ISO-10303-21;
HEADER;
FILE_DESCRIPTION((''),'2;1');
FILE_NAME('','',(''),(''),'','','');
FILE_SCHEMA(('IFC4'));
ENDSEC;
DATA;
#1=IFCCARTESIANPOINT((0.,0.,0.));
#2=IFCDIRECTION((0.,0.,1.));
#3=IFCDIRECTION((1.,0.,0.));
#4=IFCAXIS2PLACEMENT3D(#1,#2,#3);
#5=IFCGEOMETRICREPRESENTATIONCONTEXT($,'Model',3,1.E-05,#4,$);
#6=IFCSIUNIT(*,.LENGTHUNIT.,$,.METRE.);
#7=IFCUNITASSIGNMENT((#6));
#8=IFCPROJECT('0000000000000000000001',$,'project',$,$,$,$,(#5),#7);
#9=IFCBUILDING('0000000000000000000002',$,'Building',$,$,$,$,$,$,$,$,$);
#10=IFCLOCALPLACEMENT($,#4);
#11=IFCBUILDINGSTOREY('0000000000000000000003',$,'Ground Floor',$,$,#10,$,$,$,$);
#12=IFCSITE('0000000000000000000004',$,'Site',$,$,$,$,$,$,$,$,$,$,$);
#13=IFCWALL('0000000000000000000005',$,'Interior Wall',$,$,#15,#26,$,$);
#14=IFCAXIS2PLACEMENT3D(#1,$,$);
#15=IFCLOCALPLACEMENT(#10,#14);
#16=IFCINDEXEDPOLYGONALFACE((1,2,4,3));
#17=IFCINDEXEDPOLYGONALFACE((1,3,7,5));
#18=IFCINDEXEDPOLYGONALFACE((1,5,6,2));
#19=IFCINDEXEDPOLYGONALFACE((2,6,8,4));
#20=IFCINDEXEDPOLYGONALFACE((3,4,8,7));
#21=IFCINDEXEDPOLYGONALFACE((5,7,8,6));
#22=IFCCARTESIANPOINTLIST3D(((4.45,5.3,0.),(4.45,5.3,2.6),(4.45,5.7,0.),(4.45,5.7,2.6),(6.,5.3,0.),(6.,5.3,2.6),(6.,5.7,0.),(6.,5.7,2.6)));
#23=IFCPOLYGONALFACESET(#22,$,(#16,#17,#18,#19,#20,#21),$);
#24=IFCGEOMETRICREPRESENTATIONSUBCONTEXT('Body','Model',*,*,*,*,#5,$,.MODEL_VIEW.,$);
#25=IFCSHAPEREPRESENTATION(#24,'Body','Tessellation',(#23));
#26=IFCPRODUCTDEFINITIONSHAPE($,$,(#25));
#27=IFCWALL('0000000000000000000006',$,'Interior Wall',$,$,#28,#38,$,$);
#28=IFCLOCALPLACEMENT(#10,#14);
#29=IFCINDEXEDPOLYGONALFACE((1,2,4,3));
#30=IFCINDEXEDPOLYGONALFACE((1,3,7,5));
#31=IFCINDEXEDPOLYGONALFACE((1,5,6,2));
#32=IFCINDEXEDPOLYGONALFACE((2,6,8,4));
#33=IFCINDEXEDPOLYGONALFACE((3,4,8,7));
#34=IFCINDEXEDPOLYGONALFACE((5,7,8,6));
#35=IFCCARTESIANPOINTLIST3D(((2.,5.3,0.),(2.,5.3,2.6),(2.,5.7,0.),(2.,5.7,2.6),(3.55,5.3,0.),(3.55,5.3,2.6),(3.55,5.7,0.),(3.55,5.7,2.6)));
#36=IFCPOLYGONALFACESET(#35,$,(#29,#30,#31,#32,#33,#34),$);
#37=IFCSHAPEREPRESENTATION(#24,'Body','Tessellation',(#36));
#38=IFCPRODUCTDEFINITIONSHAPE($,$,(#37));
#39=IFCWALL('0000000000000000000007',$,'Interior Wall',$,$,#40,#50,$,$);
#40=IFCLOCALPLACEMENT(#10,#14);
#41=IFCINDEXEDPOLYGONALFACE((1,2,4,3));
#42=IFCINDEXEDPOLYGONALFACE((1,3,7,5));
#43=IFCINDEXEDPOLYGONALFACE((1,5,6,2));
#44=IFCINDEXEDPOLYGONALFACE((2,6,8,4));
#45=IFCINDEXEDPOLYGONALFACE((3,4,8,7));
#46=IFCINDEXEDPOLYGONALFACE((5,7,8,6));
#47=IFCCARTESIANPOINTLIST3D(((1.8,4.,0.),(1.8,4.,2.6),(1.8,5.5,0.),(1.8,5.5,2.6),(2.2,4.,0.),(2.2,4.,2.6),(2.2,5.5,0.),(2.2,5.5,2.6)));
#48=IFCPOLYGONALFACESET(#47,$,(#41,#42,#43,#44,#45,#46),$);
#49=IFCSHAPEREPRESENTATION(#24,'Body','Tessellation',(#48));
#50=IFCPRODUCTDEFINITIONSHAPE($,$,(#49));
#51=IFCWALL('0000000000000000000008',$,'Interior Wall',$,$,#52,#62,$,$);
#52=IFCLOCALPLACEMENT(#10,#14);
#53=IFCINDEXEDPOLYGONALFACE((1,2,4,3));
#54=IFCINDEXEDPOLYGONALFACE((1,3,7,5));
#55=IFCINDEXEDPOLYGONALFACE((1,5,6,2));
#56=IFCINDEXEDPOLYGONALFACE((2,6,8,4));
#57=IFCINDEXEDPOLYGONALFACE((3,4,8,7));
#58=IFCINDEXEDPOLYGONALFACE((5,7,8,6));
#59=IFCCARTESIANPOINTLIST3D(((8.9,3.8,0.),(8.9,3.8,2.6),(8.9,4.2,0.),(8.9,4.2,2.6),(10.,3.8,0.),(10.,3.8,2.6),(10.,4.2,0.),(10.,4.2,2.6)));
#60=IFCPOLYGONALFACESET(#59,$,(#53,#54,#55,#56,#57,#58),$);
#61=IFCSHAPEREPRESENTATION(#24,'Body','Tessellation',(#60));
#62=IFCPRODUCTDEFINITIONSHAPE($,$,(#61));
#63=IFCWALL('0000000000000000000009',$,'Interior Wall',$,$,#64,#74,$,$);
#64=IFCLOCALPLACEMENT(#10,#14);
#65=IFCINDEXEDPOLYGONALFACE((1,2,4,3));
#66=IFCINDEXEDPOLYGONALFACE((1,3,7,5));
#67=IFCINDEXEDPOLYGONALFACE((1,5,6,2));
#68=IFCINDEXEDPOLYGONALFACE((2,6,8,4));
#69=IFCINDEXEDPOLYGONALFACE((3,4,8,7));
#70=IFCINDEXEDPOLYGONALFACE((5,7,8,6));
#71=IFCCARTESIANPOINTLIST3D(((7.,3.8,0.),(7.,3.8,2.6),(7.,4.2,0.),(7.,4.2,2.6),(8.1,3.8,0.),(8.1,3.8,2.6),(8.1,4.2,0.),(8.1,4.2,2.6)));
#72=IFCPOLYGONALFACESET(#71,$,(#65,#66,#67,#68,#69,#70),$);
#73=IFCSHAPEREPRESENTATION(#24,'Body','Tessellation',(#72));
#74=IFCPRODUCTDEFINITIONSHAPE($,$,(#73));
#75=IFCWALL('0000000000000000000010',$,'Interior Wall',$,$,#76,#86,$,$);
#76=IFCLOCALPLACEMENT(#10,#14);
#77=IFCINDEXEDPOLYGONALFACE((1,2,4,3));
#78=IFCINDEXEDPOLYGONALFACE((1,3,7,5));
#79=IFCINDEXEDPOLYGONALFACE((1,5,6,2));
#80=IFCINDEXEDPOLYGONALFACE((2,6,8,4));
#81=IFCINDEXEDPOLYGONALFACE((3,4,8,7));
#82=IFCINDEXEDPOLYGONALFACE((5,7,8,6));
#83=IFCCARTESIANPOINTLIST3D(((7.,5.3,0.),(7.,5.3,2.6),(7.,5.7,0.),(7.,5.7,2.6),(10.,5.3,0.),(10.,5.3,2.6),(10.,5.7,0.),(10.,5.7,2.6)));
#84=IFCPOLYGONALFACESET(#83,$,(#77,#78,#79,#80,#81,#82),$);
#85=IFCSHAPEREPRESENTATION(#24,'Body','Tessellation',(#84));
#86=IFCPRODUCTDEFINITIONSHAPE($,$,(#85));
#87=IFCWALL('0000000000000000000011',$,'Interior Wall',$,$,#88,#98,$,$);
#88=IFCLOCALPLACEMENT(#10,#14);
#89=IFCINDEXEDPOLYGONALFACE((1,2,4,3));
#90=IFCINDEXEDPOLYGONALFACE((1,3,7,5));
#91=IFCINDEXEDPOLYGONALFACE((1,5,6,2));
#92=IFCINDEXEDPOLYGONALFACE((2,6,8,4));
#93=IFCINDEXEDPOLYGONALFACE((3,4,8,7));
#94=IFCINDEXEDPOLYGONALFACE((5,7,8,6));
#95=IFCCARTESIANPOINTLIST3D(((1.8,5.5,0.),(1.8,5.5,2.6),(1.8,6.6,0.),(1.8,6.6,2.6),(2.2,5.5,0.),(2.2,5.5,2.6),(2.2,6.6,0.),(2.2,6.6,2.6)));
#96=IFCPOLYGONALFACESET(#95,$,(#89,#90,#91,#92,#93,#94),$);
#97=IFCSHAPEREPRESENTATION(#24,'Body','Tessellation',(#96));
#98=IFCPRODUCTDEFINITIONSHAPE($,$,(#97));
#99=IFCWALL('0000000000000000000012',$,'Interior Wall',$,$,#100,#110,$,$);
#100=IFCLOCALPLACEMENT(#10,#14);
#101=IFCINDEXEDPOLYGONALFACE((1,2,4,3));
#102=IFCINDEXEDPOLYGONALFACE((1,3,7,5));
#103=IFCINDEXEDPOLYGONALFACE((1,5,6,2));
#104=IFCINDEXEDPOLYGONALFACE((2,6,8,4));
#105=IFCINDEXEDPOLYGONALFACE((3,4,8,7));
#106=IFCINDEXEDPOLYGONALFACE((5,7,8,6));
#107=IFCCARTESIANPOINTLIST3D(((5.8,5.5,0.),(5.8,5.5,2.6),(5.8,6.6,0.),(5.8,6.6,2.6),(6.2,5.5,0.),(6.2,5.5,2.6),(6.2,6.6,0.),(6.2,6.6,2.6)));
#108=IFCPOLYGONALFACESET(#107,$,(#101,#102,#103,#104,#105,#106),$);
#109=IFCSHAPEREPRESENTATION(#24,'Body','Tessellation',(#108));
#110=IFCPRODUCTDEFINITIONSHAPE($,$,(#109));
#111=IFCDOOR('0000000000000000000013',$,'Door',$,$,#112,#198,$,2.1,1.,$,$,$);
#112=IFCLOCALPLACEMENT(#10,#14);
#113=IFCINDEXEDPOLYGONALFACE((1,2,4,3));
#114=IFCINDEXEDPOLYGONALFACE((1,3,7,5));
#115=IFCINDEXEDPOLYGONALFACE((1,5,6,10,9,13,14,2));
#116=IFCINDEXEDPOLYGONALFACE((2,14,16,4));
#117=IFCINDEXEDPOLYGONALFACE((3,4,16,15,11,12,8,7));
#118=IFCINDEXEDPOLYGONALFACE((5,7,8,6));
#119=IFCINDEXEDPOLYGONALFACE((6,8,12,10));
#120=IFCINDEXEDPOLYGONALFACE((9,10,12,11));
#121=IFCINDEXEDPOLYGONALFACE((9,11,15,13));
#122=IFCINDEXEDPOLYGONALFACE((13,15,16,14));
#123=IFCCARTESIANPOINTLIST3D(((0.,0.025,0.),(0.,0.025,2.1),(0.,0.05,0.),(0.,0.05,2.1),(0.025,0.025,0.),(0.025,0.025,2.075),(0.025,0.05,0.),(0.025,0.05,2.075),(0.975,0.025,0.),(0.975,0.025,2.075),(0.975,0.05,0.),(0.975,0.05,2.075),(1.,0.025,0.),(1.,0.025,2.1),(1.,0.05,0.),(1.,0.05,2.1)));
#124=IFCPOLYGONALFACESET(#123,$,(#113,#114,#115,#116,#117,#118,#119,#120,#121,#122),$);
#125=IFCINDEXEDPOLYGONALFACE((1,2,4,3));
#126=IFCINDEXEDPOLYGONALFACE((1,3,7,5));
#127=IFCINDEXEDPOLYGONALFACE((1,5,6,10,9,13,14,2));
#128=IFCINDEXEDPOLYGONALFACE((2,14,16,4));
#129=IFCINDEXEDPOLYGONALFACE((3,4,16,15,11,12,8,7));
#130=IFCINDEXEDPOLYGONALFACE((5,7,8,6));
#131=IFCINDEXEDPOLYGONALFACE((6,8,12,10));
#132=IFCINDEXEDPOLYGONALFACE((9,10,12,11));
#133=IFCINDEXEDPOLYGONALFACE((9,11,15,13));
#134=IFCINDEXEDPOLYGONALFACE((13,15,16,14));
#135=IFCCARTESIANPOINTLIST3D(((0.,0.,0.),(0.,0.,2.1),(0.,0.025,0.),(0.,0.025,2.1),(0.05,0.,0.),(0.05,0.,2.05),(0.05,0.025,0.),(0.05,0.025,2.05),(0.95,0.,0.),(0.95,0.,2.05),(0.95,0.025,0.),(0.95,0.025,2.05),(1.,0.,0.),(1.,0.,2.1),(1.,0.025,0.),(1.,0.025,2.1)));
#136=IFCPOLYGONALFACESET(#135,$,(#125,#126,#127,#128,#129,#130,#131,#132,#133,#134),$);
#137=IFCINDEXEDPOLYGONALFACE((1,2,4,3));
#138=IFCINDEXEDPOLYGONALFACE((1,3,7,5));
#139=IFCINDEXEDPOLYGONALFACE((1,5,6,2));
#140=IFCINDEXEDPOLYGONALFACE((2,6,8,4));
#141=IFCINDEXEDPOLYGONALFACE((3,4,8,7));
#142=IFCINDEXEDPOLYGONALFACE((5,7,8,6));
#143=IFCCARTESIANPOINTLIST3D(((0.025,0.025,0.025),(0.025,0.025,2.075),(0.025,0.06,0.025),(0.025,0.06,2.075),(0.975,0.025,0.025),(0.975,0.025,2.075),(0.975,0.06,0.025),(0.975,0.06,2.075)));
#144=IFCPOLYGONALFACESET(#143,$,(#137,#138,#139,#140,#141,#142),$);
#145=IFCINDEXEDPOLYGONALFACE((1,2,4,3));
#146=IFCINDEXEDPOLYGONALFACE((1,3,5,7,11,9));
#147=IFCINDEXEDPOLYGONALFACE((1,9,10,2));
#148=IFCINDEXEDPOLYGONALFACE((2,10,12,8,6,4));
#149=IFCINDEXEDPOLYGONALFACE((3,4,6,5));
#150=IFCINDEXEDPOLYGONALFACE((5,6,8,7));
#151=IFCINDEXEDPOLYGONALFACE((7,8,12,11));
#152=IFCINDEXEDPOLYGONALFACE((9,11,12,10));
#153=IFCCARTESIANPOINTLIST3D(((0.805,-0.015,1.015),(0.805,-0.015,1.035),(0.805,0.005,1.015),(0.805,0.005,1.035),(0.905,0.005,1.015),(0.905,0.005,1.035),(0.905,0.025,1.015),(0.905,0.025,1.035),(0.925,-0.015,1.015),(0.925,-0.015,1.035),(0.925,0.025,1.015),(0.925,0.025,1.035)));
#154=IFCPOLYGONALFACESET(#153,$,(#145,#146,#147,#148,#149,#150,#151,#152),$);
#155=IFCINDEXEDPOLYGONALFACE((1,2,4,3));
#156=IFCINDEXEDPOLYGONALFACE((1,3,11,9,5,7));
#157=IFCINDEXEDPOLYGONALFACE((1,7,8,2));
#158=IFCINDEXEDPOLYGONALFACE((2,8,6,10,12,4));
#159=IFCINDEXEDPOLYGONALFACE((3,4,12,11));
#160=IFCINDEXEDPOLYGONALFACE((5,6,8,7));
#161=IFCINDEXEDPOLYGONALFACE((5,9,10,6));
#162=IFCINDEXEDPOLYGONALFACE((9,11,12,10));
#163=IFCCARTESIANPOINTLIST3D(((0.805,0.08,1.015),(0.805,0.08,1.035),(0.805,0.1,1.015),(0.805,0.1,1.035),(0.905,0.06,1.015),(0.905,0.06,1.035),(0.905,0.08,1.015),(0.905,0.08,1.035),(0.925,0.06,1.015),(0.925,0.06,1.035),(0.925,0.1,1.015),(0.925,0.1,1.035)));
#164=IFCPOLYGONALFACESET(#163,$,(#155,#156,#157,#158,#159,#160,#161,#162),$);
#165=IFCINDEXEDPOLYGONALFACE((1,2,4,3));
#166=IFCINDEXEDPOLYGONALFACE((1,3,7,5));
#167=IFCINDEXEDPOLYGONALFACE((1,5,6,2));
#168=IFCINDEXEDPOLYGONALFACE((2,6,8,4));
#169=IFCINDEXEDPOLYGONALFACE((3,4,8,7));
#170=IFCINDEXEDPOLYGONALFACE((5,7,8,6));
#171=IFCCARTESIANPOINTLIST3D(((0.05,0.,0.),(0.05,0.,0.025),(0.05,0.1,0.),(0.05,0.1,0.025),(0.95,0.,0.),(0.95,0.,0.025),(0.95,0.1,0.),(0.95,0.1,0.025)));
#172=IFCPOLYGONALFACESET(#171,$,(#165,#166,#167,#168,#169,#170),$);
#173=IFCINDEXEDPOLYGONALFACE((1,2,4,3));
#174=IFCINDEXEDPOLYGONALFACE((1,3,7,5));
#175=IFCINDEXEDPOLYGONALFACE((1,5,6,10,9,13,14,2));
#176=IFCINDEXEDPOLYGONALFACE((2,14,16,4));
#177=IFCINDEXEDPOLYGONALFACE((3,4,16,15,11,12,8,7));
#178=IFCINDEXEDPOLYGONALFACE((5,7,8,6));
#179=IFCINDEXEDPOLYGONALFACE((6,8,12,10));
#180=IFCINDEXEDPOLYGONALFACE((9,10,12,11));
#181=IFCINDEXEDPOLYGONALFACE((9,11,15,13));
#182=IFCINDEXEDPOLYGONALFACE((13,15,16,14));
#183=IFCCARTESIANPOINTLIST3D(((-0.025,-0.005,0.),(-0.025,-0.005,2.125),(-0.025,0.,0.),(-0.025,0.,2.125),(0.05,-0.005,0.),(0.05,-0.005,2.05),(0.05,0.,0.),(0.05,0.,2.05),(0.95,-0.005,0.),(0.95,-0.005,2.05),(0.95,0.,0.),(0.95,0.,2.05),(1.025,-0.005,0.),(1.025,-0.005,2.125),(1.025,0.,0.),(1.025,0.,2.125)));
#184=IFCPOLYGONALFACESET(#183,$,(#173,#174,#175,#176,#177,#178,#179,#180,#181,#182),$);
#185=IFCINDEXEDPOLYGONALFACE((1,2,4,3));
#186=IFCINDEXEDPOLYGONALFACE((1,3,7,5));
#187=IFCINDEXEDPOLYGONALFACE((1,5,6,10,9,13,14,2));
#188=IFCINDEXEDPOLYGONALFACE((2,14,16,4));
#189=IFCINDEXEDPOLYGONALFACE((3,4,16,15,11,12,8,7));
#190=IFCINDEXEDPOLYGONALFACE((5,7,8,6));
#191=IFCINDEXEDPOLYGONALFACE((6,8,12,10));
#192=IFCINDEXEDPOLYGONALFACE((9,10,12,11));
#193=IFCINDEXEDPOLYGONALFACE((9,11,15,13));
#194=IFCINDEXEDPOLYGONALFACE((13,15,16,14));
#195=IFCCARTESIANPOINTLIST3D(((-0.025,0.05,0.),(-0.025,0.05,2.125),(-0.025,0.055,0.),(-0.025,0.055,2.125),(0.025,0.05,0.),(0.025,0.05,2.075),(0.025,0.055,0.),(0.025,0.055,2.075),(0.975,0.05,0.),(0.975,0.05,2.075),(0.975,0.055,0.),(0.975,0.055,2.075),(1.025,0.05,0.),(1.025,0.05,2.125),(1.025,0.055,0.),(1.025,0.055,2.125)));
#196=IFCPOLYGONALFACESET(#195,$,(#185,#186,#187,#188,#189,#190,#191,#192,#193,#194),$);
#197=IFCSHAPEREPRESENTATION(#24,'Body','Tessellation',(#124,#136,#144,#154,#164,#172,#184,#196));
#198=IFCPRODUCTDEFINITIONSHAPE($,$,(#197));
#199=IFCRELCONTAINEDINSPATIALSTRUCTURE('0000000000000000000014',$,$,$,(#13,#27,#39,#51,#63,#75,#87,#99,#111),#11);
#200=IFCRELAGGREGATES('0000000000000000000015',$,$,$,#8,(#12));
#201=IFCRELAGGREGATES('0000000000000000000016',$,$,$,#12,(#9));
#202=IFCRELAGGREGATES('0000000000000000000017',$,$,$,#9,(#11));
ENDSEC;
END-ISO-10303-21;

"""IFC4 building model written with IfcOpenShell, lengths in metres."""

from ifc_helpers import new_model, si_unit, frame, origin_with_axes, place, context, subcontext, project, spatial, line, indexed_curve, outline, extrude, element, save


model = new_model("IFC4")

# Units and contexts
model_context = context("Model", 3, precision=1e-05, world=origin_with_axes())
body_context = subcontext(model_context, "Body", "Model", "MODEL_VIEW")
ifc_project = project(units=[si_unit("LENGTHUNIT", "METRE")], contexts=[model_context])

# Site, building, storey
site = spatial("IfcSite", under=ifc_project, Name="Site")
building = spatial("IfcBuilding", under=site, Name="Building")
storey_placement = place(None, origin_with_axes())
storey = spatial("IfcBuildingStorey", under=building, at=storey_placement, Name="Ground Floor")

# Walls
for number, where, z_axis, x_axis, name in (
    (1, (6.0, 5.5, 0.0), (0.0, 0.0, 1.0), (-1.0, 0.0, 0.0), "Interior Wall"),
    (2, (3.55, 5.5, 0.0), (0.0, 0.0, 1.0), (-1.0, 0.0, 0.0), "Interior Wall"),
):
    element("IfcWall", number, at=place(storey_placement, frame(where, z_axis=z_axis, x_axis=x_axis)), inside=storey, Name=name, context=body_context, shape_type="SweptSolid", body=[
        extrude(outline(indexed_curve([(0.0, 0.0), (0.0, 0.4), (1.55, 0.4), (1.55, 0.0), (0.0, 0.0)], self_intersect=False)), frame((0.0, -0.2, 0.0), z_axis=(0.0, 0.0, 1.0), x_axis=(1.0, 0.0, 0.0)), (0.0, 0.0, 1.0), 2.6),
    ])
wall_1_placement = place(storey_placement, frame((2.0, 5.5, 0.0), z_axis=(0.0, 0.0, 1.0), x_axis=(0.0, -1.0, 0.0)))
element("IfcWall", 3, at=wall_1_placement, inside=storey, Name="Interior Wall", context=body_context, shape_type="SweptSolid", body=[
    extrude(outline(indexed_curve([(0.0, 0.0), (0.0, 0.4), (1.5, 0.4), (1.5, 0.0), (0.0, 0.0)], self_intersect=False)), frame((0.0, -0.2, 0.0), z_axis=(0.0, 0.0, 1.0), x_axis=(1.0, 0.0, 0.0)), (0.0, 0.0, 1.0), 2.6),
])
for number, where, z_axis, x_axis, name in (
    (4, (10.0, 4.0, 0.0), (0.0, 0.0, 1.0), (-1.0, 0.0, 0.0), "Interior Wall"),
    (5, (8.1, 4.0, 0.0), (0.0, 0.0, 1.0), (-1.0, 0.0, 0.0), "Interior Wall"),
):
    element("IfcWall", number, at=place(storey_placement, frame(where, z_axis=z_axis, x_axis=x_axis)), inside=storey, Name=name, context=body_context, shape_type="SweptSolid", body=[
        extrude(outline(indexed_curve([(0.0, 0.0), (0.0, 0.4), (1.1, 0.4), (1.1, 0.0), (0.0, 0.0)], self_intersect=False)), frame((0.0, -0.2, 0.0), z_axis=(0.0, 0.0, 1.0), x_axis=(1.0, 0.0, 0.0)), (0.0, 0.0, 1.0), 2.6),
    ])
wall_2_placement = place(storey_placement, frame((10.0, 5.5, 0.0), z_axis=(0.0, 0.0, 1.0), x_axis=(-1.0, 0.0, 0.0)))
element("IfcWall", 6, at=wall_2_placement, inside=storey, Name="Interior Wall", context=body_context, shape_type="SweptSolid", body=[
    extrude(outline(indexed_curve([(0.0, 0.0), (0.0, 0.4), (3.0, 0.4), (3.0, 0.0), (0.0, 0.0)], self_intersect=False)), frame((0.0, -0.2, 0.0), z_axis=(0.0, 0.0, 1.0), x_axis=(1.0, 0.0, 0.0)), (0.0, 0.0, 1.0), 2.6),
])
for number, where, z_axis, x_axis, name in (
    (7, (2.0, 5.5, 0.0), (0.0, 0.0, 1.0), (0.0, 1.0, 0.0), "Interior Wall"),
    (8, (6.0, 5.5, 0.0), (0.0, 0.0, 1.0), (0.0, 1.0, 0.0), "Interior Wall"),
):
    element("IfcWall", number, at=place(storey_placement, frame(where, z_axis=z_axis, x_axis=x_axis)), inside=storey, Name=name, context=body_context, shape_type="SweptSolid", body=[
        extrude(outline(indexed_curve([(0.0, 0.0), (0.0, 0.4), (1.1, 0.4), (1.1, 0.0), (0.0, 0.0)], self_intersect=False)), frame((0.0, -0.2, 0.0), z_axis=(0.0, 0.0, 1.0), x_axis=(1.0, 0.0, 0.0)), (0.0, 0.0, 1.0), 2.6),
    ])

# Door
door_1_placement = place(storey_placement, origin_with_axes())
element("IfcDoor", 9, at=door_1_placement, inside=storey, Name="Door", OverallHeight=2.1, OverallWidth=1.0, context=body_context, shape_type="SweptSolid", body=[
    extrude(outline(indexed_curve([(0.0, 0.0), (0.0, 2.1), (1.0, 2.1), (1.0, 0.0), (0.975, 0.0), (0.975, 2.075), (0.025, 2.075), (0.025, 0.0)], segments=[line(1, 2, 3, 4, 5, 6, 7, 8, 1)])), frame((0.0, 0.025, 0.0), z_axis=(0.0, -1.0, 0.0), x_axis=(1.0, 0.0, 0.0)), (0.0, 0.0, -1.0), 0.025),
    extrude(outline(indexed_curve([(0.0, 0.0), (0.0, 2.1), (1.0, 2.1), (1.0, 0.0), (0.95, 0.0), (0.95, 2.05), (0.05, 2.05), (0.05, 0.0)], segments=[line(1, 2, 3, 4, 5, 6, 7, 8, 1)])), frame((0.0, 0.0, 0.0), z_axis=(0.0, -1.0, 0.0), x_axis=(1.0, 0.0, 0.0)), (0.0, 0.0, -1.0), 0.025),
    extrude(outline(indexed_curve([(0.0, 0.0), (0.95, 0.0), (0.95, 0.035), (0.0, 0.035)], segments=[line(1, 2, 3, 4, 1)])), frame((0.025, 0.025, 0.025), z_axis=(0.0, 0.0, 1.0), x_axis=(1.0, 0.0, 0.0)), (0.0, 0.0, 1.0), 2.05),
    extrude(outline(indexed_curve([(0.0, 0.0), (0.0, -0.04), (-0.12, -0.04), (-0.12, -0.02), (-0.02, -0.02), (-0.02, 0.0)], segments=[line(1, 2, 3, 4, 5, 6, 1)])), frame((0.925, 0.025, 1.015), z_axis=(0.0, 0.0, 1.0), x_axis=(1.0, 0.0, 0.0)), (0.0, 0.0, 1.0), 0.02),
    extrude(outline(indexed_curve([(0.0, 0.0), (0.0, 0.04), (-0.12, 0.04), (-0.12, 0.02), (-0.02, 0.02), (-0.02, 0.0)], segments=[line(1, 2, 3, 4, 5, 6, 1)])), frame((0.925, 0.06, 1.015), z_axis=(0.0, 0.0, 1.0), x_axis=(1.0, 0.0, 0.0)), (0.0, 0.0, 1.0), 0.02),
    extrude(outline(indexed_curve([(0.0, 0.0), (0.9, 0.0), (0.9, 0.1), (0.0, 0.1)], segments=[line(1, 2, 3, 4, 1)])), frame((0.05, 0.0, 0.0), z_axis=(0.0, 0.0, 1.0), x_axis=(1.0, 0.0, 0.0)), (0.0, 0.0, 1.0), 0.025),
    extrude(outline(indexed_curve([(0.0, 0.0), (0.0, 2.125), (1.05, 2.125), (1.05, 0.0), (0.975, 0.0), (0.975, 2.05), (0.075, 2.05), (0.075, 0.0)], segments=[line(1, 2, 3, 4, 5, 6, 7, 8, 1)])), frame((-0.025, -0.005, 0.0), z_axis=(0.0, -1.0, 0.0), x_axis=(1.0, 0.0, 0.0)), (0.0, 0.0, -1.0), 0.005),
    extrude(outline(indexed_curve([(0.0, 0.0), (0.0, 2.125), (1.05, 2.125), (1.05, 0.0), (1.0, 0.0), (1.0, 2.075), (0.05, 2.075), (0.05, 0.0)], segments=[line(1, 2, 3, 4, 5, 6, 7, 8, 1)])), frame((-0.025, 0.05, 0.0), z_axis=(0.0, -1.0, 0.0), x_axis=(1.0, 0.0, 0.0)), (0.0, 0.0, -1.0), 0.005),
])

save(model, "model.ifc")
